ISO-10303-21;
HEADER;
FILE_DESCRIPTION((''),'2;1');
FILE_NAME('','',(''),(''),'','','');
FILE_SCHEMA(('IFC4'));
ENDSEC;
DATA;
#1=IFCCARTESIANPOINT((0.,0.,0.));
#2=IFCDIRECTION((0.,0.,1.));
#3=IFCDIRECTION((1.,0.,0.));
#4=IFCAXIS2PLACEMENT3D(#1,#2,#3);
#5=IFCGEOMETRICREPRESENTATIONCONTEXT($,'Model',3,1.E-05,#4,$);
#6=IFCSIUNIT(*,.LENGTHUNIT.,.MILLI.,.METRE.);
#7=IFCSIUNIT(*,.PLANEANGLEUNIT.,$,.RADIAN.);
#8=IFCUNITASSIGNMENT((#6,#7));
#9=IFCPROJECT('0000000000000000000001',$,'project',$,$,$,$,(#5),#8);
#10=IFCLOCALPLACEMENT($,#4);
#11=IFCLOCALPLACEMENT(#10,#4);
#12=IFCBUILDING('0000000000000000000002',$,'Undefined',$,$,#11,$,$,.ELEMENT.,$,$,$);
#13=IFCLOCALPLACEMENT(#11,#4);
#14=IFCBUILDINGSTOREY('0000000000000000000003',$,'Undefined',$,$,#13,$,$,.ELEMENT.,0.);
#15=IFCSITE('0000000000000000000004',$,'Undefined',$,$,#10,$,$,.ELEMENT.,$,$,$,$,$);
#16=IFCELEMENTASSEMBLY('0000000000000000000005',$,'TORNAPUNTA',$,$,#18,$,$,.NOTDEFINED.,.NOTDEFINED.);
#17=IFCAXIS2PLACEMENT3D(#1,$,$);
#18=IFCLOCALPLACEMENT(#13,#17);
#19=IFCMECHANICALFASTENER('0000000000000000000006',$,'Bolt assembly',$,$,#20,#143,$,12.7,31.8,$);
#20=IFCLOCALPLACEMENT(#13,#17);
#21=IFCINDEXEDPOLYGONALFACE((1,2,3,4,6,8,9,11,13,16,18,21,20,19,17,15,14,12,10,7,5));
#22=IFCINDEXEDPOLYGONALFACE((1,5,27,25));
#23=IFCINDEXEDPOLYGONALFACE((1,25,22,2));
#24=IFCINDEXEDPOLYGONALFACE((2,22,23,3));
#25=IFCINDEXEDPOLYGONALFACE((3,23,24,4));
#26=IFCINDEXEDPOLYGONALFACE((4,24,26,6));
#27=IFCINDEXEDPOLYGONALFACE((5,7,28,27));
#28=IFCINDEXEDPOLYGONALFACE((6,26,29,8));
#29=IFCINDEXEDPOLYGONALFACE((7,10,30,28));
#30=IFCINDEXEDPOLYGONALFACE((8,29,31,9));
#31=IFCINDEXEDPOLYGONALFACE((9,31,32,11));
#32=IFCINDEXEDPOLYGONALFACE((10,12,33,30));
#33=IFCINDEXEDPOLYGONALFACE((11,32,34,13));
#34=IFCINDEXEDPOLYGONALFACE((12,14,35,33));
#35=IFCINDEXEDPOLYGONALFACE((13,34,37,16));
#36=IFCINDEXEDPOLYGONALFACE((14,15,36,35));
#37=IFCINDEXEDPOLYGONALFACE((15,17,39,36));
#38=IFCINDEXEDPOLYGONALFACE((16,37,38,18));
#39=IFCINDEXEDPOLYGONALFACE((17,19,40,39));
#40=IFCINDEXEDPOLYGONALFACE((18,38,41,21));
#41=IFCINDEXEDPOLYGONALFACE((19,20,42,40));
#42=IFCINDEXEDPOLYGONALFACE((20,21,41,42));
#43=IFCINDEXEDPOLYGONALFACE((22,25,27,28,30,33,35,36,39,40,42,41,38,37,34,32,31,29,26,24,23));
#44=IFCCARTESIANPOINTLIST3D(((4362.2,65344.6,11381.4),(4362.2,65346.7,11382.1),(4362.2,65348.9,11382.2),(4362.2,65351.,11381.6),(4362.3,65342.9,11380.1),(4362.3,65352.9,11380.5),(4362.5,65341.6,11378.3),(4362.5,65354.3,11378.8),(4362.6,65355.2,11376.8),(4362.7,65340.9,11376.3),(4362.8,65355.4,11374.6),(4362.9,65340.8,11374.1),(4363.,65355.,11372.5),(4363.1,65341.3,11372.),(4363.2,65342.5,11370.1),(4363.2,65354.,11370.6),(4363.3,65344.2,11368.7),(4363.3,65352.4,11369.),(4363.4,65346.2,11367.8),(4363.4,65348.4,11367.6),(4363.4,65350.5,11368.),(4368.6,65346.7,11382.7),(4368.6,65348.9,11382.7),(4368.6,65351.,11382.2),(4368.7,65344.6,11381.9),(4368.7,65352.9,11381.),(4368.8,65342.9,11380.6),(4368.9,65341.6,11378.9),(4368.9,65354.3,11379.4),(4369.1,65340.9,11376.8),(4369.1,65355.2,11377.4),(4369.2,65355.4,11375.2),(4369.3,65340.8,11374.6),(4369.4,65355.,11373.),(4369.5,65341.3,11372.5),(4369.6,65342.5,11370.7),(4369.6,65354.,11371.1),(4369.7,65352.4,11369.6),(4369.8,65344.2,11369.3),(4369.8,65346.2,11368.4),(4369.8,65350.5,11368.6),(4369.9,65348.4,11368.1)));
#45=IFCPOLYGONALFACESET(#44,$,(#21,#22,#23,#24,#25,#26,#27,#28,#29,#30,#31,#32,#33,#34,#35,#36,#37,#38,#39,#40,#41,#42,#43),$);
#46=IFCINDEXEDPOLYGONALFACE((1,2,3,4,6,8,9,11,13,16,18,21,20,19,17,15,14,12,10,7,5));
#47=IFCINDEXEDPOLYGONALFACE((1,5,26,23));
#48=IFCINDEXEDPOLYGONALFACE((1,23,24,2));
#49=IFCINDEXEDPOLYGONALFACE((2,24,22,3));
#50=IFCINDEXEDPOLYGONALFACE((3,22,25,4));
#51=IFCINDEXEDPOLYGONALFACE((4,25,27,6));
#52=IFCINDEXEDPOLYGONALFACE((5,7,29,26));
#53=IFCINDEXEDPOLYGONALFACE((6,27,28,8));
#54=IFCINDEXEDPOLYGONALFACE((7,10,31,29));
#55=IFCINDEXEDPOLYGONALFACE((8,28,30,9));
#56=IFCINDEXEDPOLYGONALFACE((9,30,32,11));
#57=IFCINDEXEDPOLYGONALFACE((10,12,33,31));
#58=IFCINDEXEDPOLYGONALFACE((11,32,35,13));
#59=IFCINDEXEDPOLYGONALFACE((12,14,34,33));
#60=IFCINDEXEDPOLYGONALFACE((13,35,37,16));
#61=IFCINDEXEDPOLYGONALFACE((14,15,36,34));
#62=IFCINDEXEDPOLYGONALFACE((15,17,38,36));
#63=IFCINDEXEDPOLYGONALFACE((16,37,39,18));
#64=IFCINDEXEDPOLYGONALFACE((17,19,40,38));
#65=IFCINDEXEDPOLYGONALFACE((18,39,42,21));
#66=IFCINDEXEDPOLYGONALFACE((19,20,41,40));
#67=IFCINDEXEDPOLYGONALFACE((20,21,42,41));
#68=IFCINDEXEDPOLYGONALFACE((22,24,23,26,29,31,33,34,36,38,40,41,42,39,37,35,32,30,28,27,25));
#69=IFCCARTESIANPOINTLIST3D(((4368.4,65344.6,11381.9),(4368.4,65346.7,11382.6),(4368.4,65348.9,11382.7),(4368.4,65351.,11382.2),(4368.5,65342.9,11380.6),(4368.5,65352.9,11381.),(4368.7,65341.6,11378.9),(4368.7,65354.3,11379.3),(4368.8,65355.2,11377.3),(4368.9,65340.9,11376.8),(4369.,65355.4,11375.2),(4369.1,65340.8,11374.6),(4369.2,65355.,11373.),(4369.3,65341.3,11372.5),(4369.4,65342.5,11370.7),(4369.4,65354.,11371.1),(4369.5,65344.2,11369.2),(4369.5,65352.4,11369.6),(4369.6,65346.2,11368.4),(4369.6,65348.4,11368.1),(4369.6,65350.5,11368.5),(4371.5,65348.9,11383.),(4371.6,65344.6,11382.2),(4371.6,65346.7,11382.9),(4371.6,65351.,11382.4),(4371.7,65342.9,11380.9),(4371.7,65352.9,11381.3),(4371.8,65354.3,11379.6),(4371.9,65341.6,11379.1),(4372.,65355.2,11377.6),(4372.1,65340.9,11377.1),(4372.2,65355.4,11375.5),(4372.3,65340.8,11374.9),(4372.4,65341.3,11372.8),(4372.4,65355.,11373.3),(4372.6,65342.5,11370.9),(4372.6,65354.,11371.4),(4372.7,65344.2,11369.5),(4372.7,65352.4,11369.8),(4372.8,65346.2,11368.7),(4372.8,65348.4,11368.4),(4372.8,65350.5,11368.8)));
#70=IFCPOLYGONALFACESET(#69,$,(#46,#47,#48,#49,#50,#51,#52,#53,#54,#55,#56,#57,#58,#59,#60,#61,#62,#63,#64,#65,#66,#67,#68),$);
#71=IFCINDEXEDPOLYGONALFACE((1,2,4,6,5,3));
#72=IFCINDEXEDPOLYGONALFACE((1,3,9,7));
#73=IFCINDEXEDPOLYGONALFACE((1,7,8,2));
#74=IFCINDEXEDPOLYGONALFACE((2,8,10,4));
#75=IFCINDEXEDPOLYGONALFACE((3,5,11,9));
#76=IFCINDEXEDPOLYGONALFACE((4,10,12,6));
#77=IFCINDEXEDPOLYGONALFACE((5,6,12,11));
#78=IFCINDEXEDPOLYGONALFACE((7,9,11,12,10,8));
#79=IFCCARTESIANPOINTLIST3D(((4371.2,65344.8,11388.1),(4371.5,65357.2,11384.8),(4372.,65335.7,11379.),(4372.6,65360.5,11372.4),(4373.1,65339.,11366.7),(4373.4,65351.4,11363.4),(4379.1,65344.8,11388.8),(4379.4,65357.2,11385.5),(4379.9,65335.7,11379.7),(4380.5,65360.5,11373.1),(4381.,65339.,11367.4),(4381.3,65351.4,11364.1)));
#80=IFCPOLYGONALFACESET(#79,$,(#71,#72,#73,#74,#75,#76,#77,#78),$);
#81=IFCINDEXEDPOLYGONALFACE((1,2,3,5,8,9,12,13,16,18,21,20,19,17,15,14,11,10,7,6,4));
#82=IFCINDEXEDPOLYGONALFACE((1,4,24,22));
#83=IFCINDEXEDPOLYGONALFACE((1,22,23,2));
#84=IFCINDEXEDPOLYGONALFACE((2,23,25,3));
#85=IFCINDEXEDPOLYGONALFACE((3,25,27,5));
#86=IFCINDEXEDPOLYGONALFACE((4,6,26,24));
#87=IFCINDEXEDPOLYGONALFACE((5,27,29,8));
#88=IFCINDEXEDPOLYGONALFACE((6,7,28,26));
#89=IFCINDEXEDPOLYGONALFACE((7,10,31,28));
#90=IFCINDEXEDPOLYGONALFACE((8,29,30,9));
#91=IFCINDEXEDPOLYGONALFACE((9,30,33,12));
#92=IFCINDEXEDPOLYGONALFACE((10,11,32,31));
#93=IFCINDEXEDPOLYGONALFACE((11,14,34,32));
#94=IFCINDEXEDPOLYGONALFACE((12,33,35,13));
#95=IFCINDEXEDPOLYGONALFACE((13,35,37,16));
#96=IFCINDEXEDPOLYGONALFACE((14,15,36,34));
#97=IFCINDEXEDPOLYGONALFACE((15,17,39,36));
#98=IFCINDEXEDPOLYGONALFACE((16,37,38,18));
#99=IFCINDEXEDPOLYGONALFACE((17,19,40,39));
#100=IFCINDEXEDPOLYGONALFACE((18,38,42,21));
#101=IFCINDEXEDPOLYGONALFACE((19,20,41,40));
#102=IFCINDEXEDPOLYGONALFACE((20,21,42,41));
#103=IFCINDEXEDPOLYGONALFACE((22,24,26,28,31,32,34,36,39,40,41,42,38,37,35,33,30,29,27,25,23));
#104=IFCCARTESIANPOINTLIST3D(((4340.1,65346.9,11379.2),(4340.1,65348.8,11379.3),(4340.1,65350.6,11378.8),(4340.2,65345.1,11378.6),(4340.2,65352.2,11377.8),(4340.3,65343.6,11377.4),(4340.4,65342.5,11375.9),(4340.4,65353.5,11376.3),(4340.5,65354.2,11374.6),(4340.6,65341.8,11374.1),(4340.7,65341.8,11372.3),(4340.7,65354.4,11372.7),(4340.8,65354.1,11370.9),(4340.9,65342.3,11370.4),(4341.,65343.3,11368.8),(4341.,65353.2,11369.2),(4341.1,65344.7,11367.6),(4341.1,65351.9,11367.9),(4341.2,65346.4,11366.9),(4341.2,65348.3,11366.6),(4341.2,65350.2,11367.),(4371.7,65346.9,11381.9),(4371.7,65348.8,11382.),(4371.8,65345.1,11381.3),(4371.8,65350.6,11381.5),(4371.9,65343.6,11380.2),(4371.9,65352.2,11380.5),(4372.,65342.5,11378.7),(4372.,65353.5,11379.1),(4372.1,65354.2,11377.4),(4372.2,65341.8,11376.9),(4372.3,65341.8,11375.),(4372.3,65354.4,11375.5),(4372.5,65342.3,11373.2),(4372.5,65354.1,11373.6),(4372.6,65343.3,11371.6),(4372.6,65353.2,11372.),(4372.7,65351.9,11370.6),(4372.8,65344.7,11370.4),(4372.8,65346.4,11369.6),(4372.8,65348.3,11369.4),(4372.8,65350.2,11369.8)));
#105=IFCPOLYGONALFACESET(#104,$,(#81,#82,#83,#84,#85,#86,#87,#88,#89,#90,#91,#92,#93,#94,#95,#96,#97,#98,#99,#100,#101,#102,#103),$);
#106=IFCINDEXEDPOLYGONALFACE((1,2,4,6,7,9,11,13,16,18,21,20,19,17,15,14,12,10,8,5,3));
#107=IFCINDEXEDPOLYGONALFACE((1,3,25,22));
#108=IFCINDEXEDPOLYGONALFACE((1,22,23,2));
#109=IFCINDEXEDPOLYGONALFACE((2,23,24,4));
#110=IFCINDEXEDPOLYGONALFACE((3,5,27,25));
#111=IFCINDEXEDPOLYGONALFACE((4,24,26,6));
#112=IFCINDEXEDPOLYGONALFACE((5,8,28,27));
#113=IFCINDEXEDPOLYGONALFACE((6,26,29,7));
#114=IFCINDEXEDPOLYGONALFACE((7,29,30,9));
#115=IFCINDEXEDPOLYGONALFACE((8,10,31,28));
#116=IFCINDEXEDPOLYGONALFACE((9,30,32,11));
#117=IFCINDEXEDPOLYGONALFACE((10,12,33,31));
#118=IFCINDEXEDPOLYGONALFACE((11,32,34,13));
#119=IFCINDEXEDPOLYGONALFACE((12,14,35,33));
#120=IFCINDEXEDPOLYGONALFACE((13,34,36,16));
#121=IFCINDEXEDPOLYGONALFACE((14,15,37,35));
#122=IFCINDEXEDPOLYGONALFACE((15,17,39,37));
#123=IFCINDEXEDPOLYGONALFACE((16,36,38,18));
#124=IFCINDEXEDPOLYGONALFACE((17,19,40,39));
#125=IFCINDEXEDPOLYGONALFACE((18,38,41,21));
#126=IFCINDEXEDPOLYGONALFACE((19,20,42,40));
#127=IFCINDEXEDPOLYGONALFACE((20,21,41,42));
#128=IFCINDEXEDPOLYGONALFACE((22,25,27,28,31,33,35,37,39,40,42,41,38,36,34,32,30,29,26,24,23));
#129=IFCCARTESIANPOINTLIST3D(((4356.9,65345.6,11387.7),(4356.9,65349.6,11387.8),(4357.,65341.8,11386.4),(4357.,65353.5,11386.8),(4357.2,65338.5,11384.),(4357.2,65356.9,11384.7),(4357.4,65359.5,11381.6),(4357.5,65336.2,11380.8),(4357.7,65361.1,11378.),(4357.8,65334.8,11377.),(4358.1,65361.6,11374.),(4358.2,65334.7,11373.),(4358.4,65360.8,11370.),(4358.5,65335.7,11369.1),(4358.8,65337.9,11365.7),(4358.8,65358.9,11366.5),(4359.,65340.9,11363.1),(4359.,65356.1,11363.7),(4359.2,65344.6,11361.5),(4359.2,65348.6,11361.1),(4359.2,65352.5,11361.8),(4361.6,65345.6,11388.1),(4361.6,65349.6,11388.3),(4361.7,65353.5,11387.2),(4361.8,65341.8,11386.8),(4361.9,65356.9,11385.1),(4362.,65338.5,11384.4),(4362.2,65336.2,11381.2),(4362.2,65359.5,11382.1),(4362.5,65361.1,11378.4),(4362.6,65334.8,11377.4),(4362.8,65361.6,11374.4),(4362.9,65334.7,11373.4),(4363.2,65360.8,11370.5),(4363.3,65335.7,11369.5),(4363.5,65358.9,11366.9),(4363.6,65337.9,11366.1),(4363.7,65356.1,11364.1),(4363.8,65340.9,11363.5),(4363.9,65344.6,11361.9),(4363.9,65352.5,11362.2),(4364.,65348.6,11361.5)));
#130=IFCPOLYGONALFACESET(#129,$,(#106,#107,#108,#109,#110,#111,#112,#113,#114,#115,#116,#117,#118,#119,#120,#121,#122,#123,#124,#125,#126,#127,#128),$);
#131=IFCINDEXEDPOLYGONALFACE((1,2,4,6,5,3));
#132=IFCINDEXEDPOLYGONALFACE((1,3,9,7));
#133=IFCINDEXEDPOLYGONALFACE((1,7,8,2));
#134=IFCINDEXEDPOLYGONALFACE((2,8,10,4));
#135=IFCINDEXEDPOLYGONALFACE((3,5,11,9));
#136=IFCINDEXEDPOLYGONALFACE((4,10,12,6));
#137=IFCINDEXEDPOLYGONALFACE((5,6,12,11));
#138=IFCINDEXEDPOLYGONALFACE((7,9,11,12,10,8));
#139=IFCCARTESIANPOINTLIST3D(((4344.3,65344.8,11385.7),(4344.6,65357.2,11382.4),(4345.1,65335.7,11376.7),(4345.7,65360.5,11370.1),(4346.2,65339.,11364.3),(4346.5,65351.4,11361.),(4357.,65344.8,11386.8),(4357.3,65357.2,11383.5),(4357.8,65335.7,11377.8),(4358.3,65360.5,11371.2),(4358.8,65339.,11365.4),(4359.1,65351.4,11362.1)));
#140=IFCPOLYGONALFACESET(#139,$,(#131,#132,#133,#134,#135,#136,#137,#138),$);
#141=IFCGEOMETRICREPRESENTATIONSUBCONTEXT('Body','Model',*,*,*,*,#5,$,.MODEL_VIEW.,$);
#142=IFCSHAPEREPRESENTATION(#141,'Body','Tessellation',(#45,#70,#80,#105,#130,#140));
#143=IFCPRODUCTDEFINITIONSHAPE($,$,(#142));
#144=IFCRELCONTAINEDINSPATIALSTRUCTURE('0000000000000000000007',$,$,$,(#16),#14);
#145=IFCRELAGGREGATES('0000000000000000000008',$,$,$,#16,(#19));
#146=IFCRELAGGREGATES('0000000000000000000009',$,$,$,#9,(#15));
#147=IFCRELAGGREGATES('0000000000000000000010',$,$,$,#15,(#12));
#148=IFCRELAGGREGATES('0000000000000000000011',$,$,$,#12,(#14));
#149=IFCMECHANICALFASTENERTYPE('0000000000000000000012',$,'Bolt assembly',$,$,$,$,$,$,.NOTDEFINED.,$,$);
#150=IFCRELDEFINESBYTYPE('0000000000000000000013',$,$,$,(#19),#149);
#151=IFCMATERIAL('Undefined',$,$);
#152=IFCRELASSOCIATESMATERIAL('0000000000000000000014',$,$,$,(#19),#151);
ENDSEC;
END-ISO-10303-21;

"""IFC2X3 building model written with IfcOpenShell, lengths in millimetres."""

from ifc_helpers import new_model, si_unit, frame, origin_with_axes, origin_2d_with_axis, place, context, subcontext, project, spatial, polyline, circle, outline, extrude, source, transform, mapped, material, type_object, element, aggregate, save


model = new_model("IFC2X3")

# Units and contexts
model_context = context("Model", 3, precision=1e-05, world=origin_with_axes())
body_context = subcontext(model_context, "Body", "Model", "MODEL_VIEW")
ifc_project = project(units=[si_unit("LENGTHUNIT", "METRE", prefix="MILLI"), si_unit("PLANEANGLEUNIT", "RADIAN")], contexts=[model_context])

# Site, building, storey
site_placement = place(None, origin_with_axes())
site = spatial("IfcSite", under=ifc_project, at=site_placement, Name="Undefined", CompositionType="ELEMENT")
building_placement = place(site_placement, origin_with_axes())
building = spatial("IfcBuilding", under=site, at=building_placement, Name="Undefined", CompositionType="ELEMENT")
storey_placement = place(building_placement, origin_with_axes())
storey = spatial("IfcBuildingStorey", under=building, at=storey_placement, Name="Undefined", CompositionType="ELEMENT", Elevation=0.0)

# Element assembly
assembly_1_placement = place(storey_placement, origin_with_axes())
assembly_1 = element("IfcElementAssembly", 1, at=assembly_1_placement, inside=storey, Name="TORNAPUNTA", AssemblyPlace="NOTDEFINED", PredefinedType="NOTDEFINED")

# Mechanical fastener
ifc_material_1 = material(Name="Undefined")
mechanical_fastener_type = type_object("IfcMechanicalFastenerType", Name="Bolt assembly")
shared_shape_1 = source(origin_with_axes(), body_context, "Body", "SweptSolid", [
    extrude(circle(Radius=7.3, at=origin_2d_with_axis()), frame((0.0, -0.1, 0.0), z_axis=(0.0, 1.0, 0.0), x_axis=(1.0, 0.0, 0.0)), (0.0, 0.0, 1.0), 6.5),
    extrude(circle(Radius=7.3, at=origin_2d_with_axis()), frame((0.0, -3.1, 0.0), z_axis=(0.0, 1.0, 0.0), x_axis=(1.0, 0.0, 0.0)), (0.0, 0.0, 1.0), 3.2),
    extrude(outline(polyline([(11.1, -6.4), (11.1, 6.4), (0.0, 12.8), (-11.1, 6.4), (-11.1, -6.4), (0.0, -12.8), (11.1, -6.4)])), frame((0.0, -11.1, 0.0), z_axis=(0.0, 1.0, 0.0), x_axis=(1.0, 0.0, 0.0)), (0.0, 0.0, 1.0), 7.9),
    extrude(circle(Radius=6.3, at=origin_2d_with_axis()), frame((0.0, -3.2, 0.0), z_axis=(0.0, 1.0, 0.0), x_axis=(1.0, 0.0, 0.0)), (0.0, 0.0, 1.0), 31.8),
    extrude(circle(Radius=13.5, at=origin_2d_with_axis()), frame((0.0, 6.3, 0.0), z_axis=(0.0, 1.0, 0.0), x_axis=(1.0, 0.0, 0.0)), (0.0, 0.0, 1.0), 4.8),
    extrude(outline(polyline([(11.1, -6.4), (11.1, 6.4), (0.0, 12.8), (-11.1, 6.4), (-11.1, -6.4), (0.0, -12.8), (11.1, -6.4)])), frame((0.0, 11.1, 0.0), z_axis=(0.0, 1.0, 0.0), x_axis=(1.0, 0.0, 0.0)), (0.0, 0.0, 1.0), 12.7),
])
mechanical_fastener_1_placement = place(assembly_1_placement, frame((4369.1, 65348.1, 11375.5), z_axis=(0.061628, -0.707107, -0.704416), x_axis=(-0.061628, -0.707107, 0.704416)))
mechanical_fastener_1 = element("IfcMechanicalFastener", 2, at=mechanical_fastener_1_placement, type_object=mechanical_fastener_type, material=ifc_material_1, Name="Bolt assembly", NominalDiameter=12.7, NominalLength=31.8, context=body_context, shape_type="MappedRepresentation", body=[
    mapped(shared_shape_1, transform((0.0, 0.0, 0.0))),
])
aggregate(assembly_1, [mechanical_fastener_1])

save(model, "model.ifc")
